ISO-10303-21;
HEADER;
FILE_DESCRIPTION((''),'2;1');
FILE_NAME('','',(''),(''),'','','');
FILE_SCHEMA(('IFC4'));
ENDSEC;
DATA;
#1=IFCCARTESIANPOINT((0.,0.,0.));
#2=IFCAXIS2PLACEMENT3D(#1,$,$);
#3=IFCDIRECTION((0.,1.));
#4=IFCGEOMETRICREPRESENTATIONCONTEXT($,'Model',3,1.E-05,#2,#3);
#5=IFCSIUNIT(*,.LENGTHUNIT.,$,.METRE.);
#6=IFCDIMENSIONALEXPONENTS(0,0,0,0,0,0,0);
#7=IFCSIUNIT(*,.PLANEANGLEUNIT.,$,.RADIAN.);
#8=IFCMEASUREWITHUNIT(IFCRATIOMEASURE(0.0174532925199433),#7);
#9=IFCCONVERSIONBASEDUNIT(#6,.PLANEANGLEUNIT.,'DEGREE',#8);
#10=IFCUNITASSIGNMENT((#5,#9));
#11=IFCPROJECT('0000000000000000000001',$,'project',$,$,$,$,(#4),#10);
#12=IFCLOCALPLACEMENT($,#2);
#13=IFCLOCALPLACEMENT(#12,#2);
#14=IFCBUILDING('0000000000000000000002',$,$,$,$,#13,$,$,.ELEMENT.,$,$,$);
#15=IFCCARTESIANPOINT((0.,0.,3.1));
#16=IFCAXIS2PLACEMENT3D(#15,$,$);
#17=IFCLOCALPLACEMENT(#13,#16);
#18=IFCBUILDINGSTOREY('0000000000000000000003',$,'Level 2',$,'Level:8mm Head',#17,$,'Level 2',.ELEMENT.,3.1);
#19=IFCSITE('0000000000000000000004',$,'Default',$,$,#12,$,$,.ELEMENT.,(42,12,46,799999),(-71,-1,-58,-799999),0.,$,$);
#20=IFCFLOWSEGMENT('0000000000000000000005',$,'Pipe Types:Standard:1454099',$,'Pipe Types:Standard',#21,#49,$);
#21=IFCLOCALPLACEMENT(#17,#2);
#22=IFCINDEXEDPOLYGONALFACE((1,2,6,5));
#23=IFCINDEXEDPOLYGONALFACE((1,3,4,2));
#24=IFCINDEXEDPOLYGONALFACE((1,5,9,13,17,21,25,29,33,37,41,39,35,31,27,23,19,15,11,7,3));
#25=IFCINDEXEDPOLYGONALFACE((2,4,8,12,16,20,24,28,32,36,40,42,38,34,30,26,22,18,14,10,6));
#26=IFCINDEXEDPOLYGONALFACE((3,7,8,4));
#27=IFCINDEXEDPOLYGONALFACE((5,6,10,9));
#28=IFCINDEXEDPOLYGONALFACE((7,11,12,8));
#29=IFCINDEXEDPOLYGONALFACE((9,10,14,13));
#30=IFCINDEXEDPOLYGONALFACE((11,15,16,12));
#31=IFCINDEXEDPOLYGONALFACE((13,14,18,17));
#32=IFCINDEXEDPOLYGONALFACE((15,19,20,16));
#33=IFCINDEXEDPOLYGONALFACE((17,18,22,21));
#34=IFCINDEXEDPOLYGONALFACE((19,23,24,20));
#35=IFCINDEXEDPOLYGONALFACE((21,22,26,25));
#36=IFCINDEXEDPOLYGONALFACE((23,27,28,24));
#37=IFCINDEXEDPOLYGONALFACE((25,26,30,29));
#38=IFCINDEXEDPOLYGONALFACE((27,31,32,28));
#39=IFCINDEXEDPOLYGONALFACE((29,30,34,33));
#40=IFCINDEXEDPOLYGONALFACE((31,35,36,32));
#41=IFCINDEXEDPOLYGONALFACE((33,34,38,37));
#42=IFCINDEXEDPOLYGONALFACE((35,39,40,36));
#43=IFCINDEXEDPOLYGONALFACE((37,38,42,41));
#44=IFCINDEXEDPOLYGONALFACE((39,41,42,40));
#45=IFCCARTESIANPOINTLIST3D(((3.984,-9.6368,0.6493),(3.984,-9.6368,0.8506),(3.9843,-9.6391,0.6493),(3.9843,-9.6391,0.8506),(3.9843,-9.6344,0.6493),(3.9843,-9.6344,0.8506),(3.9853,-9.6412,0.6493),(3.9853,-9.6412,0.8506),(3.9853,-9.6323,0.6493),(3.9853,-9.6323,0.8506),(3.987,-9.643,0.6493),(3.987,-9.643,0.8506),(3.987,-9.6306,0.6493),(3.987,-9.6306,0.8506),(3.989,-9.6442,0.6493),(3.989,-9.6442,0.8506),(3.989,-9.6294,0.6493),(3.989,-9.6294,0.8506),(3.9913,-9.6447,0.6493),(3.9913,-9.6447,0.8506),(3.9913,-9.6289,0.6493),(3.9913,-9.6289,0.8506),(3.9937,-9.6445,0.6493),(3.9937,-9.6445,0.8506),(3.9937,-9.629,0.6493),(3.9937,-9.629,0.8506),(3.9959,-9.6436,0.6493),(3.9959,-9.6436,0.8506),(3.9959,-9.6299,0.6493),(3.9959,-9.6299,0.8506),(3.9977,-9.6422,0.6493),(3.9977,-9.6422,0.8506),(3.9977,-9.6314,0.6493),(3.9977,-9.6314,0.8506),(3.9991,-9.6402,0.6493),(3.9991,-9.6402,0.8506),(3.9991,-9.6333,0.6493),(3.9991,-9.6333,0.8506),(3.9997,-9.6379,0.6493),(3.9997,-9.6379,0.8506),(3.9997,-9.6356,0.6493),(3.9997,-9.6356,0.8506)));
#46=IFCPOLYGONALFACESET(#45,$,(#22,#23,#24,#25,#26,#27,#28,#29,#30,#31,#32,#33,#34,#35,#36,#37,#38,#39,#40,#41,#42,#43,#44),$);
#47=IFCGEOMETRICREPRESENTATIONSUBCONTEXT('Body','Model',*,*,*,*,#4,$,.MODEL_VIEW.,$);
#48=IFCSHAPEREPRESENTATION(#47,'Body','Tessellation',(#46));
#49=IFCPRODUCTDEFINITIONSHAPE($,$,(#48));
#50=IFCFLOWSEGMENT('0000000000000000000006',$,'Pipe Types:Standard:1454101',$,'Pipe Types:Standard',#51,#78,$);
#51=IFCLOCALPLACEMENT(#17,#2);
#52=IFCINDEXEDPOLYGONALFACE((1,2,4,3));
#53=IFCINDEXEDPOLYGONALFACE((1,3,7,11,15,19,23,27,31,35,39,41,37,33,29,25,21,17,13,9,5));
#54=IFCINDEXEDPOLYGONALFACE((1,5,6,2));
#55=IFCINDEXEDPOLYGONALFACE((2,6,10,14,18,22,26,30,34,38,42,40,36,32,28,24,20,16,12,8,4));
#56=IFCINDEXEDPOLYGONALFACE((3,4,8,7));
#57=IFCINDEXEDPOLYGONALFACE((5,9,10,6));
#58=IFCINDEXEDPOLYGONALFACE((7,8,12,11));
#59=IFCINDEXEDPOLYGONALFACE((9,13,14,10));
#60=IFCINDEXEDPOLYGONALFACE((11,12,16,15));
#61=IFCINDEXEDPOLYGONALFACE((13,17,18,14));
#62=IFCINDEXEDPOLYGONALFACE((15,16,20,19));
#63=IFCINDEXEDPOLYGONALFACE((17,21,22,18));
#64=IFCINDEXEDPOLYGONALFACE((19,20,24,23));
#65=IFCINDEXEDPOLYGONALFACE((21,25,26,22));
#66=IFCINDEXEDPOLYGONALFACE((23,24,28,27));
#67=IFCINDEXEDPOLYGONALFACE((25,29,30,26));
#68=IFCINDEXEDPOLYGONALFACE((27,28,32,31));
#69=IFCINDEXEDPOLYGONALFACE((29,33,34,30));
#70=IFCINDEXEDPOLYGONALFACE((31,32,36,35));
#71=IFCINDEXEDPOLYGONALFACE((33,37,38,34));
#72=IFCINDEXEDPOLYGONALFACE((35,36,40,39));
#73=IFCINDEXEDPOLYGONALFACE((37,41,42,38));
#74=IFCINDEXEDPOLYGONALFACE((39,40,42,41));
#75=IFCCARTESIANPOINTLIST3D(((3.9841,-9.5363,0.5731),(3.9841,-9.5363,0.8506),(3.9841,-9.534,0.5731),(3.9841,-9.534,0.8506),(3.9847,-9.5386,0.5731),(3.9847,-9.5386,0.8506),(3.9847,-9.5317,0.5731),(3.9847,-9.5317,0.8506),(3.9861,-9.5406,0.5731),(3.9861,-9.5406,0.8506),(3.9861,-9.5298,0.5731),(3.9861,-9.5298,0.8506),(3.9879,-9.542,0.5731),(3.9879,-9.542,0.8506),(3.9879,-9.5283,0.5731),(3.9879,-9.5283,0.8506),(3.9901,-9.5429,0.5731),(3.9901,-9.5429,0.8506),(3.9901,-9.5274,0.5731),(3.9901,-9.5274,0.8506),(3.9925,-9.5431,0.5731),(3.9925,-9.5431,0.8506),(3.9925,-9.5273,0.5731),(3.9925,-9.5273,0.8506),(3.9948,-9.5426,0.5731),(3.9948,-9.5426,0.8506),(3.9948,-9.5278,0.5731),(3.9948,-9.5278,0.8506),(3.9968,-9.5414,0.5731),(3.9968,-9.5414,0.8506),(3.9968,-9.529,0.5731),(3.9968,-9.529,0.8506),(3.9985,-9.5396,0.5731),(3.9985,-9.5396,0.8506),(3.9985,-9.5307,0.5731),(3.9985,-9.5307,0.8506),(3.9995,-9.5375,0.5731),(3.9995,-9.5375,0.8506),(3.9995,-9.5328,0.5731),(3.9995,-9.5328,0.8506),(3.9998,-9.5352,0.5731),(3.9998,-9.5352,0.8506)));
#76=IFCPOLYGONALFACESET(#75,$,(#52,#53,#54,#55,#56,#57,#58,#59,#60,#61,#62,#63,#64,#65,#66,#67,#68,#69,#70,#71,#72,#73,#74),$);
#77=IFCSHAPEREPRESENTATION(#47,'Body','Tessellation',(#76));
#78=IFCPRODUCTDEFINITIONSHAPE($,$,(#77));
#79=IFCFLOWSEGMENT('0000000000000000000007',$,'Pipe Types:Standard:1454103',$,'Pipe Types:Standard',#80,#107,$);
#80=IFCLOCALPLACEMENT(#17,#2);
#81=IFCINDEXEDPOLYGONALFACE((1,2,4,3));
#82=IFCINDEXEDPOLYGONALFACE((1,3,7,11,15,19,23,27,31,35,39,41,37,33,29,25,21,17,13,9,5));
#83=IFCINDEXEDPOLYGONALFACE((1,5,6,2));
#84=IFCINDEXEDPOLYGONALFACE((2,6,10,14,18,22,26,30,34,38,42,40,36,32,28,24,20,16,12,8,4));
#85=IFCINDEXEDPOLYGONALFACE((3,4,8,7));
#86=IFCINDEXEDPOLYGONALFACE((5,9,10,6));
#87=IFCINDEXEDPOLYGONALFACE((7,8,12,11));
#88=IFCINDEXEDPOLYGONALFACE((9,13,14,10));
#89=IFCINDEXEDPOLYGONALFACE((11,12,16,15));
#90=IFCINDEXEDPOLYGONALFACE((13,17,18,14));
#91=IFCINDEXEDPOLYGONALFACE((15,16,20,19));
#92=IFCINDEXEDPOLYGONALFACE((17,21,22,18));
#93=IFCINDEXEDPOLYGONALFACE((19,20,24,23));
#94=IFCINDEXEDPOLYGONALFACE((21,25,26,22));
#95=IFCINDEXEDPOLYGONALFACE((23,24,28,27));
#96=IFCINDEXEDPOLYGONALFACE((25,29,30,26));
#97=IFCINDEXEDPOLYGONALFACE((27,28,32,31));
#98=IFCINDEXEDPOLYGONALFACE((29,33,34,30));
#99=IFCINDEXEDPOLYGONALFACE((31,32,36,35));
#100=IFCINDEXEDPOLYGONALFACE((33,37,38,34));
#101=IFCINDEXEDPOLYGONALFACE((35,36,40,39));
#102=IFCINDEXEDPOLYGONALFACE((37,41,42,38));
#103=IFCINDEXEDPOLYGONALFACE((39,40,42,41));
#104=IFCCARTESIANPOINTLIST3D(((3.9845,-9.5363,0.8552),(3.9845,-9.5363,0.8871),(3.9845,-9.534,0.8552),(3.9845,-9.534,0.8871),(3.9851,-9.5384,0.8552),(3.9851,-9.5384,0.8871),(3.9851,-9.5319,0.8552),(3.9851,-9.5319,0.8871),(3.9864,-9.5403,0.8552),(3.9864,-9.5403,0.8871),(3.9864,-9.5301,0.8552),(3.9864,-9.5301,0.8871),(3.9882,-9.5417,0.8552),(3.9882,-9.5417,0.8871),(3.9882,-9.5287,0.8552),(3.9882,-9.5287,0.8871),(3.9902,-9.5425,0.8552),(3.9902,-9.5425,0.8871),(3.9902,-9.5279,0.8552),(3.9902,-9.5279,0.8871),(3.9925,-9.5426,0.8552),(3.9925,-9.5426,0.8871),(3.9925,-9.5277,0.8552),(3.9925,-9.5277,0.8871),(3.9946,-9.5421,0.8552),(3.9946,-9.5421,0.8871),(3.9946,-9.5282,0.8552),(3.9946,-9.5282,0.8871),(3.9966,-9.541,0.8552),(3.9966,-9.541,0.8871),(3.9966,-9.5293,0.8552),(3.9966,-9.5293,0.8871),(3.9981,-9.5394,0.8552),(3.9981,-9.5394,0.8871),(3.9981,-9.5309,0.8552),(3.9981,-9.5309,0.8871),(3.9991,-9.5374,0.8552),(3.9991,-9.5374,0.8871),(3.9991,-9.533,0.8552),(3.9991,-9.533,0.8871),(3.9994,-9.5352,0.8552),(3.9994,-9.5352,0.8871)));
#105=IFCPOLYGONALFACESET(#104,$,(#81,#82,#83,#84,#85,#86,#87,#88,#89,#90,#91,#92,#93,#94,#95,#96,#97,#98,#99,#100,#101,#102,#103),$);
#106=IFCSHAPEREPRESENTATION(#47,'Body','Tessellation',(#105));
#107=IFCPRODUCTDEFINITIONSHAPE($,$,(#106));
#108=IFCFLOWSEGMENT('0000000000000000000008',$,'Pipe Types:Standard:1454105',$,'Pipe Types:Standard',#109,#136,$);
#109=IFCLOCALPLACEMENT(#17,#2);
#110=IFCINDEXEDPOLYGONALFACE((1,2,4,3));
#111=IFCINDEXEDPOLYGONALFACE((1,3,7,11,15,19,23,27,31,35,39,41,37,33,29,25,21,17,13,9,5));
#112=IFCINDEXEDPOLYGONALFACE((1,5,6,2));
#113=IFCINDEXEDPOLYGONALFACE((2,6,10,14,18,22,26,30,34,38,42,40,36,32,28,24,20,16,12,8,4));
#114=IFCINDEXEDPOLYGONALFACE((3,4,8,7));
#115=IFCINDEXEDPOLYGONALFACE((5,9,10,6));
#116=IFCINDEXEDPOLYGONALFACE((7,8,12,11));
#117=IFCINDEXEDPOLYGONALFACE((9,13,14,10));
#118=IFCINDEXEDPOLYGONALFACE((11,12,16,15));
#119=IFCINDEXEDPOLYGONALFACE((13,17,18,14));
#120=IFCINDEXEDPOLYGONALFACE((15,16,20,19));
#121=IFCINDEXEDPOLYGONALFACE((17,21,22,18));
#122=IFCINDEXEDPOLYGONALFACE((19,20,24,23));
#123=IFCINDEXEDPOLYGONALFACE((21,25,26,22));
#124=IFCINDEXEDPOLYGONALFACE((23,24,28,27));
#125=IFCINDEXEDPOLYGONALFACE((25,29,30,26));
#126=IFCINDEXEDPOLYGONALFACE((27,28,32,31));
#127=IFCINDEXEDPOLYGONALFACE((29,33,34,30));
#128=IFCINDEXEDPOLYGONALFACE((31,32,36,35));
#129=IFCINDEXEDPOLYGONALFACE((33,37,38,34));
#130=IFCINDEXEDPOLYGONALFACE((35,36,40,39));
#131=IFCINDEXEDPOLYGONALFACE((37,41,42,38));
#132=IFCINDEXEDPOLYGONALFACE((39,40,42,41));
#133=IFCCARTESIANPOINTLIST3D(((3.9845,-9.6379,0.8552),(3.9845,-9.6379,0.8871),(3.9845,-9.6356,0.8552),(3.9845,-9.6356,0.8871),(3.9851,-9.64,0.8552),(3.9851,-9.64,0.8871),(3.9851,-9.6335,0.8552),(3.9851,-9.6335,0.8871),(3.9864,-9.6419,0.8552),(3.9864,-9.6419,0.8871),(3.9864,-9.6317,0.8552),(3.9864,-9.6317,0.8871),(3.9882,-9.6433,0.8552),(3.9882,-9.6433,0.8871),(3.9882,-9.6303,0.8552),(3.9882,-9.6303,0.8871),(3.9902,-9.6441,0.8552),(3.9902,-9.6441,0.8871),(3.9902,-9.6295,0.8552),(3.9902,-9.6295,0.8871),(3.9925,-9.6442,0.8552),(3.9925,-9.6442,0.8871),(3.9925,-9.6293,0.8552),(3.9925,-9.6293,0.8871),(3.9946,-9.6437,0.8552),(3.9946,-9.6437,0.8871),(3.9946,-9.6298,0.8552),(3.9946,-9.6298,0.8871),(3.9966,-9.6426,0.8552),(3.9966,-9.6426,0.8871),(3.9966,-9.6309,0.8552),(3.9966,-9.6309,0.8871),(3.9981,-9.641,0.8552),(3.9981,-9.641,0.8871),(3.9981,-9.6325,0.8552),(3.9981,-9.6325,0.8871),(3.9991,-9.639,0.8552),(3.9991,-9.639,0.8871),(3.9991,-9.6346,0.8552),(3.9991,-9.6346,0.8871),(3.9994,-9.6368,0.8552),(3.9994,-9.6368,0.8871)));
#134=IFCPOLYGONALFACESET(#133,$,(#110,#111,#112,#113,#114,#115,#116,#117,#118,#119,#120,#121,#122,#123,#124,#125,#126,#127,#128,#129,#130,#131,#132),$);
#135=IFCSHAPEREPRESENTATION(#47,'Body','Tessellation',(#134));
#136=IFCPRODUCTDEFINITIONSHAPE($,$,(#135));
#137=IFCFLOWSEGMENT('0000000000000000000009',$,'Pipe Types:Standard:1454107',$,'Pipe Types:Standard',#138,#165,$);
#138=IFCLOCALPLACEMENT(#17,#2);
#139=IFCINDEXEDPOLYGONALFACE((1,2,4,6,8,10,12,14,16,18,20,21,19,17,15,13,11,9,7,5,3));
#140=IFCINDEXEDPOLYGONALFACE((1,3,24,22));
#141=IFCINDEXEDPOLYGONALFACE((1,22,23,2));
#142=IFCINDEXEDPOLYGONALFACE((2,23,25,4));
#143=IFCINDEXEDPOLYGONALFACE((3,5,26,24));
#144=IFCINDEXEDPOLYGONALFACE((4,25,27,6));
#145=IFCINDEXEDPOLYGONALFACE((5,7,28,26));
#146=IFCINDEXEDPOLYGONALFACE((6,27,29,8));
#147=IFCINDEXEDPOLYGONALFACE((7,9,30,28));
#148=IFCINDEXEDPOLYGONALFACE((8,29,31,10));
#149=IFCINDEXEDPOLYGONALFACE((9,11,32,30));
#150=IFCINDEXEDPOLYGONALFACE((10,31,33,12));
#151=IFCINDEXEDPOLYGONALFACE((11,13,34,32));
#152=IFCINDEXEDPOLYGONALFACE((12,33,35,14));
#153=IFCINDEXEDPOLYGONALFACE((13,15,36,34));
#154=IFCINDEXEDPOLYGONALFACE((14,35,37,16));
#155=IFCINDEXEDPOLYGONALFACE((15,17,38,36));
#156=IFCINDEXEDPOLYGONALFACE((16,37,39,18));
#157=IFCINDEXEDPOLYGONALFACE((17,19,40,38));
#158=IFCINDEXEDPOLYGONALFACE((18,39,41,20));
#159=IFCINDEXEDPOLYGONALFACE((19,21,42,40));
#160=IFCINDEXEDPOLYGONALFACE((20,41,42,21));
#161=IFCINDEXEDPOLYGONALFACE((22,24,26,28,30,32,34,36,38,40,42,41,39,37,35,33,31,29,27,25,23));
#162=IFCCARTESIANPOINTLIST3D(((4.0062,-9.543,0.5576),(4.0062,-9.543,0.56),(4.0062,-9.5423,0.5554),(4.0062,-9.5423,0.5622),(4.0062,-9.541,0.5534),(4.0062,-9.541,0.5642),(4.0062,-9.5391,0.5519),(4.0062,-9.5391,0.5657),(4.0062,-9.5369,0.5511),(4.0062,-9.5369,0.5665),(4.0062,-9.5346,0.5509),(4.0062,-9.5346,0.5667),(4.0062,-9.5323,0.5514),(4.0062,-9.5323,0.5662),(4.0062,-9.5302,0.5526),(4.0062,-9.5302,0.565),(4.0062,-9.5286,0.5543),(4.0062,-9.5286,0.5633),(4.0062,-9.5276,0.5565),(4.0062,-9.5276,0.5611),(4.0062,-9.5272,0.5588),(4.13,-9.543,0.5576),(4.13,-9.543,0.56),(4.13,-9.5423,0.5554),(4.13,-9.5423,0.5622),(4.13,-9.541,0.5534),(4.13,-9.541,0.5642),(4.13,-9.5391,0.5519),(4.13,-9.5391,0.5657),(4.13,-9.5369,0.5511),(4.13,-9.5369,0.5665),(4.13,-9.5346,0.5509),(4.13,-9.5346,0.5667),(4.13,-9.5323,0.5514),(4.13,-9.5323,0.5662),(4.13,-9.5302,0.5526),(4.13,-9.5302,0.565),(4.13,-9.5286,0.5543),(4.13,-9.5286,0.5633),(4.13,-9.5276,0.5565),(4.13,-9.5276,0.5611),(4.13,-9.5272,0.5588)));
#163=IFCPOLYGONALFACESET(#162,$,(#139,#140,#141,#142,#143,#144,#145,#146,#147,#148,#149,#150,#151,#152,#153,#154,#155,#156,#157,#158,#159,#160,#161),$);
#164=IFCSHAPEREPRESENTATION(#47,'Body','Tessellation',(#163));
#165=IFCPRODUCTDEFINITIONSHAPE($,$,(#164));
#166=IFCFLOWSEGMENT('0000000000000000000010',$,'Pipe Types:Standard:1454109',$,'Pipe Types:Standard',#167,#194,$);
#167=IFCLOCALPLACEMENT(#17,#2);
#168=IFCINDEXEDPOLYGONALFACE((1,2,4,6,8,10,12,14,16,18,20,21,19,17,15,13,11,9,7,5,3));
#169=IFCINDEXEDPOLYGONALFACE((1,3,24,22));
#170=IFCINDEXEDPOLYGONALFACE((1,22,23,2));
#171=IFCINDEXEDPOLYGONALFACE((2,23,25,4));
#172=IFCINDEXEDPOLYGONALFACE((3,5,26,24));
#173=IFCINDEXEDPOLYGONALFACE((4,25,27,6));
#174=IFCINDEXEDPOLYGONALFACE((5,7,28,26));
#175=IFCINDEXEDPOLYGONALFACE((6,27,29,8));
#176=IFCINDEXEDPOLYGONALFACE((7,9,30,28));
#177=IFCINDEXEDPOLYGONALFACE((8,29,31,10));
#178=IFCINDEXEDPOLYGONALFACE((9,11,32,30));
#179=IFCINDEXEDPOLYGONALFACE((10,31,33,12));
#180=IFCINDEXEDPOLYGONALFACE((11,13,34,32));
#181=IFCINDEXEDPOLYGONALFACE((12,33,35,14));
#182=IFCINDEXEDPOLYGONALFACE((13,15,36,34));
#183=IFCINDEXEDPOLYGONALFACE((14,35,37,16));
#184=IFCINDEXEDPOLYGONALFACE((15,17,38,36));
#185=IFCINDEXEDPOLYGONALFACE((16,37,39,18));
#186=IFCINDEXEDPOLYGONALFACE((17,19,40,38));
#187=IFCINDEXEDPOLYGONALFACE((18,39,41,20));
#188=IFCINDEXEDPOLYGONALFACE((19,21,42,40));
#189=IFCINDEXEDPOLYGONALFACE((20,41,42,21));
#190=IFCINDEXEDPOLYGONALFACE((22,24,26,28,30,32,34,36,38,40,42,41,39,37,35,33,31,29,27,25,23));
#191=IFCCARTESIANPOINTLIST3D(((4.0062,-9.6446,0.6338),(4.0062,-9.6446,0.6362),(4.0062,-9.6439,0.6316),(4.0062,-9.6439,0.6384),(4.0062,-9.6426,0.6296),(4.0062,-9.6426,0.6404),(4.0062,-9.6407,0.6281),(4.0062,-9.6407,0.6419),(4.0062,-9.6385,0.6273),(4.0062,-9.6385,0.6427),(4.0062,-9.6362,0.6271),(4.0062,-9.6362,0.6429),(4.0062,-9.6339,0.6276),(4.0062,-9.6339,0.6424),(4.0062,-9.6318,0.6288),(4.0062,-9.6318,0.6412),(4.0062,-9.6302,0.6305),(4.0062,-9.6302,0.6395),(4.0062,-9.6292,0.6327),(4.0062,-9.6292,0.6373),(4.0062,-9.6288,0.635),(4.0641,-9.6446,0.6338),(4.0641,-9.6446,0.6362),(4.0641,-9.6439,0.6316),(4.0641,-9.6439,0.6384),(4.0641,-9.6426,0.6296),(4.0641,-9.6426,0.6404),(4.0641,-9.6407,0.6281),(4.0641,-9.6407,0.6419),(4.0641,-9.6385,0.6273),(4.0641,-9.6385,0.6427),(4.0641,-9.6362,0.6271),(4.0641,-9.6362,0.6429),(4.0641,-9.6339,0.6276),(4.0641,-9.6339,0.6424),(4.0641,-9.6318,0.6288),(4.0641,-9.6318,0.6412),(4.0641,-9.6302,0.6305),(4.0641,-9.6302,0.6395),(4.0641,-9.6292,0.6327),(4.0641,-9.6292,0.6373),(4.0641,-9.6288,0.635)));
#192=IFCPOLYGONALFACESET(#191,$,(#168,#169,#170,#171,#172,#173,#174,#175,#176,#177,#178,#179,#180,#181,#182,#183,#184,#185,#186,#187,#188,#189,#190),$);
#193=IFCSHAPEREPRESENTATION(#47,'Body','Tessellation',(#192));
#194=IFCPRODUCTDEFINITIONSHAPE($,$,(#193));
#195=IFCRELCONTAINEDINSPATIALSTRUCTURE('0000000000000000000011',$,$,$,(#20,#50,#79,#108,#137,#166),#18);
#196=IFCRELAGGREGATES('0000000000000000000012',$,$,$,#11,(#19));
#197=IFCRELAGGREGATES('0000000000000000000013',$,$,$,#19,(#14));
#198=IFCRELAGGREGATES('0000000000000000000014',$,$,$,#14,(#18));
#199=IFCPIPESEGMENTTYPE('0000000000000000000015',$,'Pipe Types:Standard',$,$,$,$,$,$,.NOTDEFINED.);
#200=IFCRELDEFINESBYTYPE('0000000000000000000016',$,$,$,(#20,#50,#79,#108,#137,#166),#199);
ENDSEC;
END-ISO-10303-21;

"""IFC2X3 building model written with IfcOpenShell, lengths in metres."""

from ifc_helpers import new_model, entity, si_unit, converted_unit, direction, frame, frame_2d, origin, origin_2d_with_axis, place, context, subcontext, project, spatial, circle, extrude, type_object, element, save


model = new_model("IFC2X3")

# Units and contexts
model_context = context("Model", 3, precision=1e-05, world=origin(), true_north=direction((0.0, 1.0)))
body_context = subcontext(model_context, "Body", "Model", "MODEL_VIEW")
ifc_project = project(units=[si_unit("LENGTHUNIT", "METRE"), converted_unit("PLANEANGLEUNIT", "DEGREE", entity("IfcRatioMeasure", 0.0174532925199433), si_unit("PLANEANGLEUNIT", "RADIAN"), dimensions=[0, 0, 0, 0, 0, 0, 0])], contexts=[model_context])

# Site, building, storey
site_placement = place(None, origin())
site = spatial("IfcSite", under=ifc_project, at=site_placement, Name="Default", CompositionType="ELEMENT", RefLatitude=(42, 12, 46, 799999), RefLongitude=(-71, -1, -58, -799999), RefElevation=0.0)
building_placement = place(site_placement, origin())
building = spatial("IfcBuilding", under=site, at=building_placement, CompositionType="ELEMENT")
storey_placement = place(building_placement, frame((0.0, 0.0, 3.1)))
storey = spatial("IfcBuildingStorey", under=building, at=storey_placement, Name="Level 2", ObjectType="Level:8mm Head", LongName="Level 2", CompositionType="ELEMENT", Elevation=3.1)

# Flow segments
pipe_segment_type = type_object("IfcPipeSegmentType", Name="Pipe Types:Standard", PredefinedType="NOTDEFINED")
flow_segment_1_placement = place(storey_placement, origin())
element("IfcFlowSegment", 1, at=flow_segment_1_placement, inside=storey, type_object=pipe_segment_type, Name="Pipe Types:Standard:1454099", ObjectType="Pipe Types:Standard", context=body_context, shape_type="SweptSolid", body=[
    extrude(circle(Radius=0.0079, at=frame_2d((0.0, 0.0), x_axis=(1.0, 0.0))), frame((3.9919, -9.6368, 0.6493), z_axis=(0.0, 0.0, 1.0), x_axis=(-1.0, 0.0, 0.0)), (0.0, 0.0, 1.0), 0.2013),
])
flow_segment_2_placement = place(storey_placement, origin())
element("IfcFlowSegment", 2, at=flow_segment_2_placement, inside=storey, type_object=pipe_segment_type, Name="Pipe Types:Standard:1454101", ObjectType="Pipe Types:Standard", context=body_context, shape_type="SweptSolid", body=[
    extrude(circle(Radius=0.0079, at=origin_2d_with_axis()), frame((3.9919, -9.5352, 0.5731)), (0.0, 0.0, 1.0), 0.2775),
])
flow_segment_3_placement = place(storey_placement, origin())
element("IfcFlowSegment", 3, at=flow_segment_3_placement, inside=storey, type_object=pipe_segment_type, Name="Pipe Types:Standard:1454103", ObjectType="Pipe Types:Standard", context=body_context, shape_type="SweptSolid", body=[
    extrude(circle(Radius=0.0075, at=origin_2d_with_axis()), frame((3.9919, -9.5352, 0.8552)), (0.0, 0.0, 1.0), 0.032),
])
flow_segment_4_placement = place(storey_placement, origin())
element("IfcFlowSegment", 4, at=flow_segment_4_placement, inside=storey, type_object=pipe_segment_type, Name="Pipe Types:Standard:1454105", ObjectType="Pipe Types:Standard", context=body_context, shape_type="SweptSolid", body=[
    extrude(circle(Radius=0.0075, at=origin_2d_with_axis()), frame((3.9919, -9.6368, 0.8552)), (0.0, 0.0, 1.0), 0.032),
])
flow_segment_5_placement = place(storey_placement, origin())
element("IfcFlowSegment", 5, at=flow_segment_5_placement, inside=storey, type_object=pipe_segment_type, Name="Pipe Types:Standard:1454107", ObjectType="Pipe Types:Standard", context=body_context, shape_type="SweptSolid", body=[
    extrude(circle(Radius=0.0079, at=frame_2d((0.0, 0.0), x_axis=(1.0, 0.0))), frame((4.0062, -9.5352, 0.5588), z_axis=(1.0, 0.0, 0.0), x_axis=(0.0, 1.0, 0.0)), (0.0, 0.0, 1.0), 0.1238),
])
flow_segment_6_placement = place(storey_placement, origin())
element("IfcFlowSegment", 6, at=flow_segment_6_placement, inside=storey, type_object=pipe_segment_type, Name="Pipe Types:Standard:1454109", ObjectType="Pipe Types:Standard", context=body_context, shape_type="SweptSolid", body=[
    extrude(circle(Radius=0.0079, at=frame_2d((0.0, 0.0), x_axis=(1.0, 0.0))), frame((4.0062, -9.6368, 0.635), z_axis=(1.0, 0.0, 0.0), x_axis=(0.0, 1.0, 0.0)), (0.0, 0.0, 1.0), 0.0579),
])

save(model, "model.ifc")
